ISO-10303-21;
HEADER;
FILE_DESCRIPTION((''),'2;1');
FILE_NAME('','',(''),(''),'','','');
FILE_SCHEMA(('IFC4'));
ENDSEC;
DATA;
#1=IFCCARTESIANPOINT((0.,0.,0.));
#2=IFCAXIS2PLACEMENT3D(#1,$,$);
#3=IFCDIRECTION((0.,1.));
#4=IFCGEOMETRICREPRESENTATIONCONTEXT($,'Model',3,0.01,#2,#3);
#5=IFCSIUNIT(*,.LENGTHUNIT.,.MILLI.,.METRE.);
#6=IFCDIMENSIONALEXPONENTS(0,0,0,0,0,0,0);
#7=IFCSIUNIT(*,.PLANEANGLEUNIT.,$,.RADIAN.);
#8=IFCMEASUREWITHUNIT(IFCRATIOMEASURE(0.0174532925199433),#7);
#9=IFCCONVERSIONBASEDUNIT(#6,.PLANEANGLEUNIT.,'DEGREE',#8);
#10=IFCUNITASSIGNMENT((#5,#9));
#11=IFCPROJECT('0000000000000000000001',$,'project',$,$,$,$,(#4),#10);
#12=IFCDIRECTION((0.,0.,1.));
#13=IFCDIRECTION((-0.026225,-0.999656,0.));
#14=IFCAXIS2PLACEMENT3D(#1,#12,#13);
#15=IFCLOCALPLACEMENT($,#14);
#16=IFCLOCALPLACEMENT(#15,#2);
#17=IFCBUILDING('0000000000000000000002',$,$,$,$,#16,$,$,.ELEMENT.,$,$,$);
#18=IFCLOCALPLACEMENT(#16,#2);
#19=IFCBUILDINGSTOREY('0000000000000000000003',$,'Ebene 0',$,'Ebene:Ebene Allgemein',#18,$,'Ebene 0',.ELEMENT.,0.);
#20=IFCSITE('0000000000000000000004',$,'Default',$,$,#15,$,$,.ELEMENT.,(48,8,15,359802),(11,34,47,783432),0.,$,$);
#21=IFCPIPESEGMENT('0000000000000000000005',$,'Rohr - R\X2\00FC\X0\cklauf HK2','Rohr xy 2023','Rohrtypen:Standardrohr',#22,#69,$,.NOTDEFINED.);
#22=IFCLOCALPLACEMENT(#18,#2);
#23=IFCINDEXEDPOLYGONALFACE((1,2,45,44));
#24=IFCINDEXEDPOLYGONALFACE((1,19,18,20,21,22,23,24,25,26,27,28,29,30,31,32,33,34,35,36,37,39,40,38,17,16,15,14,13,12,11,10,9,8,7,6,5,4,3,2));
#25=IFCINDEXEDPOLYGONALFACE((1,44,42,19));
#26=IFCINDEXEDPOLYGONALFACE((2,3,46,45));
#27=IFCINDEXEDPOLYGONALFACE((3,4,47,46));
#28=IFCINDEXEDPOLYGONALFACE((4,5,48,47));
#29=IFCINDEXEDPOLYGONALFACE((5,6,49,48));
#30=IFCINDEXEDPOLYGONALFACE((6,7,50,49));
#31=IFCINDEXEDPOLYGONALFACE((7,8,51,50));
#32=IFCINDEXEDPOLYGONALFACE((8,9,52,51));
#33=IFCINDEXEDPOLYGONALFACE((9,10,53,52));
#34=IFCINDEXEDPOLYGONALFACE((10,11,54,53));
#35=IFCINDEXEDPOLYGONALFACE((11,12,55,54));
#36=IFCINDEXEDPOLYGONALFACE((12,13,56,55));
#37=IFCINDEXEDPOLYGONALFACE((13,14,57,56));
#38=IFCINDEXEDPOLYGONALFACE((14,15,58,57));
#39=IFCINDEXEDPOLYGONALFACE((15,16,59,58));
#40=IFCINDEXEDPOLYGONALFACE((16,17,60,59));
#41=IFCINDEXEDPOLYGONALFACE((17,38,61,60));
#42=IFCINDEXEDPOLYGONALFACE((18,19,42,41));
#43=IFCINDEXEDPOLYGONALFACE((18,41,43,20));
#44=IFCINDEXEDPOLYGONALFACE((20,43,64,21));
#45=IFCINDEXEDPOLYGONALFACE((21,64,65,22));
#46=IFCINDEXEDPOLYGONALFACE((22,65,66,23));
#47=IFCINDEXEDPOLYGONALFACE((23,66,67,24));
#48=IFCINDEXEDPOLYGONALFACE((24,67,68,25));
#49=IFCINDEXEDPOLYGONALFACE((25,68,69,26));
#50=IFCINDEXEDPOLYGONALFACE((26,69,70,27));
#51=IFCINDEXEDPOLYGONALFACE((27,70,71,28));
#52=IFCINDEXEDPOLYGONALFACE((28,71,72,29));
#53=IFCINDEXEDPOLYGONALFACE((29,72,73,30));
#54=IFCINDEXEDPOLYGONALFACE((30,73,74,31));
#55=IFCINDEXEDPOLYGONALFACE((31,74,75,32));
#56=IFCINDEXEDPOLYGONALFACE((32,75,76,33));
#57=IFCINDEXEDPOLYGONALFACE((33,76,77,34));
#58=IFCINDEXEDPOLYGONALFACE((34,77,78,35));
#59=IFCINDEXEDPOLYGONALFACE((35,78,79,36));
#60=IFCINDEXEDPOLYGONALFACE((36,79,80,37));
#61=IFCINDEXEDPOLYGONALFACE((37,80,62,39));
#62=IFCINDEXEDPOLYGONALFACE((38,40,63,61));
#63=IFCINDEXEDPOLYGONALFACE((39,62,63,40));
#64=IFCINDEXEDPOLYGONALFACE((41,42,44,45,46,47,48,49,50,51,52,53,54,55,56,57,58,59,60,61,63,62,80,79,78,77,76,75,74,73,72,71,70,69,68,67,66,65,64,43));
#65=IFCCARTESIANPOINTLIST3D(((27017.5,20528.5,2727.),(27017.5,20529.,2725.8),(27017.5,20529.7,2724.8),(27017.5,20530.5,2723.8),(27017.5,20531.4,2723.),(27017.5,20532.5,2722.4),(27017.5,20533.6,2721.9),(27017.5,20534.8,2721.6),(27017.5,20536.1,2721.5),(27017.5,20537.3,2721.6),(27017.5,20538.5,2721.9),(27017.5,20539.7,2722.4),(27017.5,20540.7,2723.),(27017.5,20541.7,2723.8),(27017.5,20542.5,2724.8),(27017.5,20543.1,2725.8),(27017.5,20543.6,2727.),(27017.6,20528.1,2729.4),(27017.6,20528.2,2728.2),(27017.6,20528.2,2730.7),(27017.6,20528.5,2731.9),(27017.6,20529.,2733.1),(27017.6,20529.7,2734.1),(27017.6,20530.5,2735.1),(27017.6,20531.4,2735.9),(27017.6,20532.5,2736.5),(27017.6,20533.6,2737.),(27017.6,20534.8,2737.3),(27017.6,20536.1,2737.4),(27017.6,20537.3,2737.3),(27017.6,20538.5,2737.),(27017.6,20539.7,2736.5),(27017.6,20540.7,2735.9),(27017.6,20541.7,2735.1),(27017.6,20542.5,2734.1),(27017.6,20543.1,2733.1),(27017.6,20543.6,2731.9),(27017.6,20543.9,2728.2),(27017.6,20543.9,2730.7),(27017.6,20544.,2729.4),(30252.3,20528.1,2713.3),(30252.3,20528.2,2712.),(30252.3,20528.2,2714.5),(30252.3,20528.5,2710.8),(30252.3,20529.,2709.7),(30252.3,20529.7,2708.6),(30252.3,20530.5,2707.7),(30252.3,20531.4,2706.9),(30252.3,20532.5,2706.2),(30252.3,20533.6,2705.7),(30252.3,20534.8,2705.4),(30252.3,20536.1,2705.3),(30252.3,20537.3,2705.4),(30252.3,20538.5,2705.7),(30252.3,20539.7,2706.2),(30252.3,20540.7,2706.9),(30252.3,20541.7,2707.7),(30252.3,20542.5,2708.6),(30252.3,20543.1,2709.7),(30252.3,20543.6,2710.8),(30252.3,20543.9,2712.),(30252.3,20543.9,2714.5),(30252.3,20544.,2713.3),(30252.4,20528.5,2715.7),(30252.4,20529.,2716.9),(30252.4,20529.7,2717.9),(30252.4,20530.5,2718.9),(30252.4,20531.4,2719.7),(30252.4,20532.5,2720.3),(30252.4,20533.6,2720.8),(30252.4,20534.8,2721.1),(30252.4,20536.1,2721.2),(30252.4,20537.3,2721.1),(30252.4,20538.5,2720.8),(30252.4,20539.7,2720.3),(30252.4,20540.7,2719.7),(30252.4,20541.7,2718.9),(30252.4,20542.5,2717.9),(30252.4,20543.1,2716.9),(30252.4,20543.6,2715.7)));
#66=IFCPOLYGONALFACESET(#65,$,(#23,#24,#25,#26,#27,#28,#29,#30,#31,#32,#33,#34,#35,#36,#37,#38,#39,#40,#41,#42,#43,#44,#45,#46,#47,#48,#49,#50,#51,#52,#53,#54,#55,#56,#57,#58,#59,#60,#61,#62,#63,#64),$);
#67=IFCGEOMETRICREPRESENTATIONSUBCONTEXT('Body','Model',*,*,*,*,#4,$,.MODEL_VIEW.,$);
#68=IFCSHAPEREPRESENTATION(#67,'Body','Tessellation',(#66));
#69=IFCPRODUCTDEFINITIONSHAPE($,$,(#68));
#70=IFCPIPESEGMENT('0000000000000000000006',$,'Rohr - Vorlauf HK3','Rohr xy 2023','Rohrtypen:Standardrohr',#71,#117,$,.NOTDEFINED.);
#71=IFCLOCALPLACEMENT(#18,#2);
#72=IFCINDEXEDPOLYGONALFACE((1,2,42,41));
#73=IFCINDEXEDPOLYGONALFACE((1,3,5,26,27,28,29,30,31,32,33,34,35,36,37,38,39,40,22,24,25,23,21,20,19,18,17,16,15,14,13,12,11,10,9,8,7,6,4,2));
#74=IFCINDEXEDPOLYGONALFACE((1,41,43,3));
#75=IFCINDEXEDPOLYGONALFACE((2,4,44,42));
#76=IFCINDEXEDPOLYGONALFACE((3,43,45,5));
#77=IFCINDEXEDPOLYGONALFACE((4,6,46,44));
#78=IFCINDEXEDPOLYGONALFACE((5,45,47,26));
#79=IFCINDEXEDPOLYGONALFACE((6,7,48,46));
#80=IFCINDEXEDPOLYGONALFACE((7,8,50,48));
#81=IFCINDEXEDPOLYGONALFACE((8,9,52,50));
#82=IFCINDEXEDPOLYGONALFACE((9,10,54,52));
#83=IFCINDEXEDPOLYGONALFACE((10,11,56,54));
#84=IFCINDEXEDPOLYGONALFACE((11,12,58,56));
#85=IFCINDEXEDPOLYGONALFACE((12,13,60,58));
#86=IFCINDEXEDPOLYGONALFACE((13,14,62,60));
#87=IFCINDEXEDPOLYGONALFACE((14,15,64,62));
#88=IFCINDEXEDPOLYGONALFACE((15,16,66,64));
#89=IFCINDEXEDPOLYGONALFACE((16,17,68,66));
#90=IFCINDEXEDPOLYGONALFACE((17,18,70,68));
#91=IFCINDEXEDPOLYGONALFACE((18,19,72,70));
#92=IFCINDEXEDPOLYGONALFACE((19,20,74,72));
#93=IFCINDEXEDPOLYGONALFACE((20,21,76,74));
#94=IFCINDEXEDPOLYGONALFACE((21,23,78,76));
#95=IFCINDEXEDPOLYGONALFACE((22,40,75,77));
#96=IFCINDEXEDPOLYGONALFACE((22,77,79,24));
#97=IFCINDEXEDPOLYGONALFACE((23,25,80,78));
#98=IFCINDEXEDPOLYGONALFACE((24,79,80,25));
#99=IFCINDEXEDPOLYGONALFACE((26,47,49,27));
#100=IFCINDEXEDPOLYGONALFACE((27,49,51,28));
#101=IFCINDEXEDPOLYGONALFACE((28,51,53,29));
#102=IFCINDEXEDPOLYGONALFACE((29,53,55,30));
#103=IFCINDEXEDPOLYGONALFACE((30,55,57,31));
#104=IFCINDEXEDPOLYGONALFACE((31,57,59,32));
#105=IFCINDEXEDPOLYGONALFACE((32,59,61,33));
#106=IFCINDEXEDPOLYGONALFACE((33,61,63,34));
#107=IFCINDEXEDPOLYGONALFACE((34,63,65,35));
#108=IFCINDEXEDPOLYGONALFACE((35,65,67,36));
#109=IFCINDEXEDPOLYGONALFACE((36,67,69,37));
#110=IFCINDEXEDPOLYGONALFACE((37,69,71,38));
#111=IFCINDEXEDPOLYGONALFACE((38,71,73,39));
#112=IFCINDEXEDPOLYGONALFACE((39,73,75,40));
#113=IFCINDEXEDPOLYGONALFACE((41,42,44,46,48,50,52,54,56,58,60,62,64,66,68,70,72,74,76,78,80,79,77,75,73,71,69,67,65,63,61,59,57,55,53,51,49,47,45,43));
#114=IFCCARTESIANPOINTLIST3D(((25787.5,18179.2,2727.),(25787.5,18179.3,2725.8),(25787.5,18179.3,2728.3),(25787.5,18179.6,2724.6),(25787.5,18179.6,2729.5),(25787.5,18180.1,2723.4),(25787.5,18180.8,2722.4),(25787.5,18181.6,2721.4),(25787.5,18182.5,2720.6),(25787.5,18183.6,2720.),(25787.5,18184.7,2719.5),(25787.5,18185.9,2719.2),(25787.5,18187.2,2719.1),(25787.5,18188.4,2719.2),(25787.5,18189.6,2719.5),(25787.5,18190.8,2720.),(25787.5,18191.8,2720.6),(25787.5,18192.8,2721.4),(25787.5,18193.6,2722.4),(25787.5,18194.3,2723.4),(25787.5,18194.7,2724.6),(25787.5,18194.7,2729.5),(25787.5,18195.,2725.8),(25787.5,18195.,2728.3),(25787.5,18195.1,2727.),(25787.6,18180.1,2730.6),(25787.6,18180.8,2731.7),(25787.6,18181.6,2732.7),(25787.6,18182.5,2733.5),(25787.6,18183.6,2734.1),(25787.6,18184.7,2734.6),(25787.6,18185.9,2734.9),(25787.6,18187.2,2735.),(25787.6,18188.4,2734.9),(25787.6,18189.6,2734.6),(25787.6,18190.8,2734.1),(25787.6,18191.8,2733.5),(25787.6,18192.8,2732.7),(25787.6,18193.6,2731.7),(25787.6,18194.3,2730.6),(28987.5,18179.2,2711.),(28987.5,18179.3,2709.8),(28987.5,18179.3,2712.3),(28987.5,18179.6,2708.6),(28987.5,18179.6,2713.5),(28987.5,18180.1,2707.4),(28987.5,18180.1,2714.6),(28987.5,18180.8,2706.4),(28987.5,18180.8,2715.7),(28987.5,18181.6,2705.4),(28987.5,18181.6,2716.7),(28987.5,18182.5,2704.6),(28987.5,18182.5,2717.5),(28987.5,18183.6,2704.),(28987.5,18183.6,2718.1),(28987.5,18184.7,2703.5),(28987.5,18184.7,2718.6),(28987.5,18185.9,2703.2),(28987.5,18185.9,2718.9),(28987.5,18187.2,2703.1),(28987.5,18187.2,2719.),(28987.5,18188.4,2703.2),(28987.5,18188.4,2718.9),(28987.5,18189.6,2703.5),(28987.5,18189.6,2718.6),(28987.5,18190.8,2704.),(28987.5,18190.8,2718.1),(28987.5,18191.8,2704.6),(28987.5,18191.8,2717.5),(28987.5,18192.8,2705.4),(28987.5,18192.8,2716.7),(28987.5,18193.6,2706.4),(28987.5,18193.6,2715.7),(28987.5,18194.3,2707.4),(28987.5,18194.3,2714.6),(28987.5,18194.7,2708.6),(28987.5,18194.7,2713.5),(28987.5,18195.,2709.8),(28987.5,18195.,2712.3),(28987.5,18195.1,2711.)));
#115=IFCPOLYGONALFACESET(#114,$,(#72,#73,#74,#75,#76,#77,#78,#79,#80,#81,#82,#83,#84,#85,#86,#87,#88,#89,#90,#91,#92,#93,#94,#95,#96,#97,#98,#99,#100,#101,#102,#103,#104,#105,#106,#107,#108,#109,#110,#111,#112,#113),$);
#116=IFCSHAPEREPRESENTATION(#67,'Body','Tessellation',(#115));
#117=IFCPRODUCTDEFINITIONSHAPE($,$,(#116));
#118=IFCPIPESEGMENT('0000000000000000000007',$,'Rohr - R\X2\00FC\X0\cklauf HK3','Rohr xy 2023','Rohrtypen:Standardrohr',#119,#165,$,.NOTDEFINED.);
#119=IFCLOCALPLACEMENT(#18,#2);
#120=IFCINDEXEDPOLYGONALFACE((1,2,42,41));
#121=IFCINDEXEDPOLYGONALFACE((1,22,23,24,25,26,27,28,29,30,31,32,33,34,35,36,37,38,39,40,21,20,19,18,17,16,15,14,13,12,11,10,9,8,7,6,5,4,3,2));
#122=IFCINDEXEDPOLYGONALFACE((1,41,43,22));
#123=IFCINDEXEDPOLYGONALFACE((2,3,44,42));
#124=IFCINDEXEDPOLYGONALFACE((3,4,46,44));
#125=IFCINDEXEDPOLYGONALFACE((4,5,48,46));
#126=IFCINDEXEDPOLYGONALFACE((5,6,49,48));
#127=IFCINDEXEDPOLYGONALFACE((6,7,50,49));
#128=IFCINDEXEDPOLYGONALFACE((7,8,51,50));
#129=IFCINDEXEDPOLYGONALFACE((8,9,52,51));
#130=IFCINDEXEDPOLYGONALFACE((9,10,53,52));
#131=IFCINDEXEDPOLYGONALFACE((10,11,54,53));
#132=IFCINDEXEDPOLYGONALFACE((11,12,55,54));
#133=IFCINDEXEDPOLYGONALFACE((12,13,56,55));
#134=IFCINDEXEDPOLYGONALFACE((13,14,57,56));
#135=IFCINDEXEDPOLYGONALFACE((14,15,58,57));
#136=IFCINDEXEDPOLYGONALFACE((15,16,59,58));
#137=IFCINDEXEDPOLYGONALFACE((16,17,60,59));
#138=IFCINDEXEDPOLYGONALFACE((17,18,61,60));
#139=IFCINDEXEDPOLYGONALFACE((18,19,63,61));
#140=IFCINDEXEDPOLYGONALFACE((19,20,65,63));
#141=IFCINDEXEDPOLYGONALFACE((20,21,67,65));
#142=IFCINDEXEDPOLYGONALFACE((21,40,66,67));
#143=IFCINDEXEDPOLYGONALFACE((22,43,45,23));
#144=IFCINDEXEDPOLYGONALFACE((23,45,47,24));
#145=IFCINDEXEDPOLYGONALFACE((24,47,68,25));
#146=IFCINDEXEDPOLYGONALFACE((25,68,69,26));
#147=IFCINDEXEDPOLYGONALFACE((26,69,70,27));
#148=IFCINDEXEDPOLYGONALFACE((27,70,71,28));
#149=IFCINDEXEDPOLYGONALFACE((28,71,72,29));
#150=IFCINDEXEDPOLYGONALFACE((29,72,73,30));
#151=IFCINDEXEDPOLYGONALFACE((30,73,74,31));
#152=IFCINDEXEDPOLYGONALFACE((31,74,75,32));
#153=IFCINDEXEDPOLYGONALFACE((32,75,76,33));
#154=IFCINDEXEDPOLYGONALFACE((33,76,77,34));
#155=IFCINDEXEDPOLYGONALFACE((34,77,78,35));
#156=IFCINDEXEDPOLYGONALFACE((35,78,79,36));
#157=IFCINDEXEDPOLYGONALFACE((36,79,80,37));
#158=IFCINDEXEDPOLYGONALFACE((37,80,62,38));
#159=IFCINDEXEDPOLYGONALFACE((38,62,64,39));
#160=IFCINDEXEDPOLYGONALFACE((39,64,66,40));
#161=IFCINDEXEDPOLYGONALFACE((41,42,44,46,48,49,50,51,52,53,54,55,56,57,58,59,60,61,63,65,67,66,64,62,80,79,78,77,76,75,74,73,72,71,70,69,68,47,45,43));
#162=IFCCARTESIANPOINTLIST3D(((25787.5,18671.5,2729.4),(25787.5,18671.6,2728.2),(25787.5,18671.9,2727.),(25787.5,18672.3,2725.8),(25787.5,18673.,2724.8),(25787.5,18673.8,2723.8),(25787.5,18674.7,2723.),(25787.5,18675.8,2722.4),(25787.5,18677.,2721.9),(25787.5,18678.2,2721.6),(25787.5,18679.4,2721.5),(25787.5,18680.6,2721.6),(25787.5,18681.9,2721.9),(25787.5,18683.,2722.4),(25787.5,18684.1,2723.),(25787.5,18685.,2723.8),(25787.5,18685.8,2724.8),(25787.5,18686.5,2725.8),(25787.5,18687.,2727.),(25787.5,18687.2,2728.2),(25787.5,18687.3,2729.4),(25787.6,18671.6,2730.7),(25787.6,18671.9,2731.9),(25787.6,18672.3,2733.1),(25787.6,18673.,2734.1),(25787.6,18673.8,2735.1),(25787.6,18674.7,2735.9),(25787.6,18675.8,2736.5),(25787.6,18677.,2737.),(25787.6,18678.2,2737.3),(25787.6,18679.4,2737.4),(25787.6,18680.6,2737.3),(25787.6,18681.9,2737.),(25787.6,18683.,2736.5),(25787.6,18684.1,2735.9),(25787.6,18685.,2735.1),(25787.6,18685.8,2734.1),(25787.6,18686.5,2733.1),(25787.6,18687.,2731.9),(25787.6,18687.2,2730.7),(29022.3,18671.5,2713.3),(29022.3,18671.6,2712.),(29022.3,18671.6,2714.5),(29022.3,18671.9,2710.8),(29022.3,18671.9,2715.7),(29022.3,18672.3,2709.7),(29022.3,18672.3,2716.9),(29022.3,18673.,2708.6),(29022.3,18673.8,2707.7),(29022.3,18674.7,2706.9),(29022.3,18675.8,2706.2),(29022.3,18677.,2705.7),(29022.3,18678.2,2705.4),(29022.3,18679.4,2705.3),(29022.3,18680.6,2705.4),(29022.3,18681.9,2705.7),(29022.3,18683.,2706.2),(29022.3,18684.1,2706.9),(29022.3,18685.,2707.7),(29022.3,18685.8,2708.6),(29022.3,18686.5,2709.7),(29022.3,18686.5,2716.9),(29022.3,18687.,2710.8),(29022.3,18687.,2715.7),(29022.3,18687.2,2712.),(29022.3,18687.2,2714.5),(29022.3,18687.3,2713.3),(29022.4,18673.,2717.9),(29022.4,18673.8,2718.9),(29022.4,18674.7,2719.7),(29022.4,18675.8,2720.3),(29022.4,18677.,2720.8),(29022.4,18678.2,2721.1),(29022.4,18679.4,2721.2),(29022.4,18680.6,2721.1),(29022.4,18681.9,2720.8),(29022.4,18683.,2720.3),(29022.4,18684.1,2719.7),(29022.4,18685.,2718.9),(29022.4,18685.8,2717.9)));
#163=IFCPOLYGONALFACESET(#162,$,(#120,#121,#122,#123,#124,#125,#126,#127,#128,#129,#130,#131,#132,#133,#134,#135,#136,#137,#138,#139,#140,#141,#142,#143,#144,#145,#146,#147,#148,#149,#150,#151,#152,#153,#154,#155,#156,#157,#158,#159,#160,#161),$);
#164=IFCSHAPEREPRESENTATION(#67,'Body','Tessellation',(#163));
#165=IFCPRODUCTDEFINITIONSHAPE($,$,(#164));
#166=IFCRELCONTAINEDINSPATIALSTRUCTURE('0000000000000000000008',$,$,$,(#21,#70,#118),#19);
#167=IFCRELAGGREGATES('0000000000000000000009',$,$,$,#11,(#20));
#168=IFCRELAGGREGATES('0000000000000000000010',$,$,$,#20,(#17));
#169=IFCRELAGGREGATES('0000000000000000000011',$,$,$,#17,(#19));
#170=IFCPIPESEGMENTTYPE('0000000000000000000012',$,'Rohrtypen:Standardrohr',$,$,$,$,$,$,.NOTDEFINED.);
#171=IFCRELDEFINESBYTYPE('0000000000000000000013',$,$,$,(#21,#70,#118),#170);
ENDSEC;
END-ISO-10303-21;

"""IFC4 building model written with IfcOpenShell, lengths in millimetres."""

from ifc_helpers import new_model, entity, si_unit, converted_unit, direction, frame, origin, place, context, subcontext, project, spatial, indexed_curve, outline, extrude, type_object, element, save


model = new_model("IFC4")

# Units and contexts
model_context = context("Model", 3, precision=0.01, world=origin(), true_north=direction((0.0, 1.0)))
body_context = subcontext(model_context, "Body", "Model", "MODEL_VIEW")
ifc_project = project(units=[si_unit("LENGTHUNIT", "METRE", prefix="MILLI"), converted_unit("PLANEANGLEUNIT", "DEGREE", entity("IfcRatioMeasure", 0.0174532925199433), si_unit("PLANEANGLEUNIT", "RADIAN"), dimensions=[0, 0, 0, 0, 0, 0, 0])], contexts=[model_context])

# Site, building, storey
site_placement = place(None, frame((0.0, 0.0, 0.0), z_axis=(0.0, 0.0, 1.0), x_axis=(-0.026225, -0.999656, 0.0)))
site = spatial("IfcSite", under=ifc_project, at=site_placement, Name="Default", CompositionType="ELEMENT", RefLatitude=(48, 8, 15, 359802), RefLongitude=(11, 34, 47, 783432), RefElevation=0.0)
building_placement = place(site_placement, origin())
building = spatial("IfcBuilding", under=site, at=building_placement, CompositionType="ELEMENT")
storey_placement = place(building_placement, origin())
storey = spatial("IfcBuildingStorey", under=building, at=storey_placement, Name="Ebene 0", ObjectType="Ebene:Ebene Allgemein", LongName="Ebene 0", CompositionType="ELEMENT", Elevation=0.0)

# Pipe segments
pipe_segment_type = type_object("IfcPipeSegmentType", Name="Rohrtypen:Standardrohr", PredefinedType="NOTDEFINED")
pipe_segment_1_placement = place(storey_placement, origin())
element("IfcPipeSegment", 1, at=pipe_segment_1_placement, inside=storey, type_object=pipe_segment_type, Name="Rohr - Rücklauf HK2", Description="Rohr xy 2023", ObjectType="Rohrtypen:Standardrohr", PredefinedType="NOTDEFINED", context=body_context, shape_type="SweptSolid", body=[
    extrude(outline(indexed_curve([(7.9, 0.0), (7.8, 1.2), (7.6, 2.5), (7.1, 3.6), (6.4, 4.7), (5.6, 5.6), (4.7, 6.4), (3.6, 7.1), (2.5, 7.6), (1.2, 7.8), (0.0, 7.9), (-1.2, 7.8), (-2.5, 7.6), (-3.6, 7.1), (-4.7, 6.4), (-5.6, 5.6), (-6.4, 4.7), (-7.1, 3.6), (-7.6, 2.5), (-7.8, 1.2), (-7.9, 0.0), (-7.8, -1.2), (-7.6, -2.5), (-7.1, -3.6), (-6.4, -4.7), (-5.6, -5.6), (-4.7, -6.4), (-3.6, -7.1), (-2.5, -7.6), (-1.2, -7.8), (0.0, -7.9), (1.2, -7.8), (2.5, -7.6), (3.6, -7.1), (4.7, -6.4), (5.6, -5.6), (6.4, -4.7), (7.1, -3.6), (7.6, -2.5), (7.8, -1.2), (7.9, 0.0)], self_intersect=False)), frame((30252.3, 20536.1, 2713.3), z_axis=(-0.999988, 0.0, 0.005), x_axis=(0.0, 1.0, 0.0)), (0.0, 0.0, 1.0), 3234.8),
])
pipe_segment_2_placement = place(storey_placement, origin())
element("IfcPipeSegment", 2, at=pipe_segment_2_placement, inside=storey, type_object=pipe_segment_type, Name="Rohr - Vorlauf HK3", Description="Rohr xy 2023", ObjectType="Rohrtypen:Standardrohr", PredefinedType="NOTDEFINED", context=body_context, shape_type="SweptSolid", body=[
    extrude(outline(indexed_curve([(7.9, 0.0), (7.8, 1.2), (7.6, 2.5), (7.1, 3.6), (6.4, 4.7), (5.6, 5.6), (4.7, 6.4), (3.6, 7.1), (2.5, 7.6), (1.2, 7.8), (0.0, 7.9), (-1.2, 7.8), (-2.5, 7.6), (-3.6, 7.1), (-4.7, 6.4), (-5.6, 5.6), (-6.4, 4.7), (-7.1, 3.6), (-7.6, 2.5), (-7.8, 1.2), (-7.9, 0.0), (-7.8, -1.2), (-7.6, -2.5), (-7.1, -3.6), (-6.4, -4.7), (-5.6, -5.6), (-4.7, -6.4), (-3.6, -7.1), (-2.5, -7.6), (-1.2, -7.8), (0.0, -7.9), (1.2, -7.8), (2.5, -7.6), (3.6, -7.1), (4.7, -6.4), (5.6, -5.6), (6.4, -4.7), (7.1, -3.6), (7.6, -2.5), (7.8, -1.2), (7.9, 0.0)], self_intersect=False)), frame((28987.5, 18187.2, 2711.0), z_axis=(-0.999988, 0.0, 0.005), x_axis=(0.0, 1.0, 0.0)), (0.0, 0.0, 1.0), 3200.0),
])
pipe_segment_3_placement = place(storey_placement, origin())
element("IfcPipeSegment", 3, at=pipe_segment_3_placement, inside=storey, type_object=pipe_segment_type, Name="Rohr - Rücklauf HK3", Description="Rohr xy 2023", ObjectType="Rohrtypen:Standardrohr", PredefinedType="NOTDEFINED", context=body_context, shape_type="SweptSolid", body=[
    extrude(outline(indexed_curve([(7.9, 0.0), (7.8, 1.2), (7.6, 2.5), (7.1, 3.6), (6.4, 4.7), (5.6, 5.6), (4.7, 6.4), (3.6, 7.1), (2.5, 7.6), (1.2, 7.8), (0.0, 7.9), (-1.2, 7.8), (-2.5, 7.6), (-3.6, 7.1), (-4.7, 6.4), (-5.6, 5.6), (-6.4, 4.7), (-7.1, 3.6), (-7.6, 2.5), (-7.8, 1.2), (-7.9, 0.0), (-7.8, -1.2), (-7.6, -2.5), (-7.1, -3.6), (-6.4, -4.7), (-5.6, -5.6), (-4.7, -6.4), (-3.6, -7.1), (-2.5, -7.6), (-1.2, -7.8), (0.0, -7.9), (1.2, -7.8), (2.5, -7.6), (3.6, -7.1), (4.7, -6.4), (5.6, -5.6), (6.4, -4.7), (7.1, -3.6), (7.6, -2.5), (7.8, -1.2), (7.9, 0.0)], self_intersect=False)), frame((29022.3, 18679.4, 2713.3), z_axis=(-0.999988, 0.0, 0.005), x_axis=(0.0, 1.0, 0.0)), (0.0, 0.0, 1.0), 3234.8),
])

save(model, "model.ifc")
